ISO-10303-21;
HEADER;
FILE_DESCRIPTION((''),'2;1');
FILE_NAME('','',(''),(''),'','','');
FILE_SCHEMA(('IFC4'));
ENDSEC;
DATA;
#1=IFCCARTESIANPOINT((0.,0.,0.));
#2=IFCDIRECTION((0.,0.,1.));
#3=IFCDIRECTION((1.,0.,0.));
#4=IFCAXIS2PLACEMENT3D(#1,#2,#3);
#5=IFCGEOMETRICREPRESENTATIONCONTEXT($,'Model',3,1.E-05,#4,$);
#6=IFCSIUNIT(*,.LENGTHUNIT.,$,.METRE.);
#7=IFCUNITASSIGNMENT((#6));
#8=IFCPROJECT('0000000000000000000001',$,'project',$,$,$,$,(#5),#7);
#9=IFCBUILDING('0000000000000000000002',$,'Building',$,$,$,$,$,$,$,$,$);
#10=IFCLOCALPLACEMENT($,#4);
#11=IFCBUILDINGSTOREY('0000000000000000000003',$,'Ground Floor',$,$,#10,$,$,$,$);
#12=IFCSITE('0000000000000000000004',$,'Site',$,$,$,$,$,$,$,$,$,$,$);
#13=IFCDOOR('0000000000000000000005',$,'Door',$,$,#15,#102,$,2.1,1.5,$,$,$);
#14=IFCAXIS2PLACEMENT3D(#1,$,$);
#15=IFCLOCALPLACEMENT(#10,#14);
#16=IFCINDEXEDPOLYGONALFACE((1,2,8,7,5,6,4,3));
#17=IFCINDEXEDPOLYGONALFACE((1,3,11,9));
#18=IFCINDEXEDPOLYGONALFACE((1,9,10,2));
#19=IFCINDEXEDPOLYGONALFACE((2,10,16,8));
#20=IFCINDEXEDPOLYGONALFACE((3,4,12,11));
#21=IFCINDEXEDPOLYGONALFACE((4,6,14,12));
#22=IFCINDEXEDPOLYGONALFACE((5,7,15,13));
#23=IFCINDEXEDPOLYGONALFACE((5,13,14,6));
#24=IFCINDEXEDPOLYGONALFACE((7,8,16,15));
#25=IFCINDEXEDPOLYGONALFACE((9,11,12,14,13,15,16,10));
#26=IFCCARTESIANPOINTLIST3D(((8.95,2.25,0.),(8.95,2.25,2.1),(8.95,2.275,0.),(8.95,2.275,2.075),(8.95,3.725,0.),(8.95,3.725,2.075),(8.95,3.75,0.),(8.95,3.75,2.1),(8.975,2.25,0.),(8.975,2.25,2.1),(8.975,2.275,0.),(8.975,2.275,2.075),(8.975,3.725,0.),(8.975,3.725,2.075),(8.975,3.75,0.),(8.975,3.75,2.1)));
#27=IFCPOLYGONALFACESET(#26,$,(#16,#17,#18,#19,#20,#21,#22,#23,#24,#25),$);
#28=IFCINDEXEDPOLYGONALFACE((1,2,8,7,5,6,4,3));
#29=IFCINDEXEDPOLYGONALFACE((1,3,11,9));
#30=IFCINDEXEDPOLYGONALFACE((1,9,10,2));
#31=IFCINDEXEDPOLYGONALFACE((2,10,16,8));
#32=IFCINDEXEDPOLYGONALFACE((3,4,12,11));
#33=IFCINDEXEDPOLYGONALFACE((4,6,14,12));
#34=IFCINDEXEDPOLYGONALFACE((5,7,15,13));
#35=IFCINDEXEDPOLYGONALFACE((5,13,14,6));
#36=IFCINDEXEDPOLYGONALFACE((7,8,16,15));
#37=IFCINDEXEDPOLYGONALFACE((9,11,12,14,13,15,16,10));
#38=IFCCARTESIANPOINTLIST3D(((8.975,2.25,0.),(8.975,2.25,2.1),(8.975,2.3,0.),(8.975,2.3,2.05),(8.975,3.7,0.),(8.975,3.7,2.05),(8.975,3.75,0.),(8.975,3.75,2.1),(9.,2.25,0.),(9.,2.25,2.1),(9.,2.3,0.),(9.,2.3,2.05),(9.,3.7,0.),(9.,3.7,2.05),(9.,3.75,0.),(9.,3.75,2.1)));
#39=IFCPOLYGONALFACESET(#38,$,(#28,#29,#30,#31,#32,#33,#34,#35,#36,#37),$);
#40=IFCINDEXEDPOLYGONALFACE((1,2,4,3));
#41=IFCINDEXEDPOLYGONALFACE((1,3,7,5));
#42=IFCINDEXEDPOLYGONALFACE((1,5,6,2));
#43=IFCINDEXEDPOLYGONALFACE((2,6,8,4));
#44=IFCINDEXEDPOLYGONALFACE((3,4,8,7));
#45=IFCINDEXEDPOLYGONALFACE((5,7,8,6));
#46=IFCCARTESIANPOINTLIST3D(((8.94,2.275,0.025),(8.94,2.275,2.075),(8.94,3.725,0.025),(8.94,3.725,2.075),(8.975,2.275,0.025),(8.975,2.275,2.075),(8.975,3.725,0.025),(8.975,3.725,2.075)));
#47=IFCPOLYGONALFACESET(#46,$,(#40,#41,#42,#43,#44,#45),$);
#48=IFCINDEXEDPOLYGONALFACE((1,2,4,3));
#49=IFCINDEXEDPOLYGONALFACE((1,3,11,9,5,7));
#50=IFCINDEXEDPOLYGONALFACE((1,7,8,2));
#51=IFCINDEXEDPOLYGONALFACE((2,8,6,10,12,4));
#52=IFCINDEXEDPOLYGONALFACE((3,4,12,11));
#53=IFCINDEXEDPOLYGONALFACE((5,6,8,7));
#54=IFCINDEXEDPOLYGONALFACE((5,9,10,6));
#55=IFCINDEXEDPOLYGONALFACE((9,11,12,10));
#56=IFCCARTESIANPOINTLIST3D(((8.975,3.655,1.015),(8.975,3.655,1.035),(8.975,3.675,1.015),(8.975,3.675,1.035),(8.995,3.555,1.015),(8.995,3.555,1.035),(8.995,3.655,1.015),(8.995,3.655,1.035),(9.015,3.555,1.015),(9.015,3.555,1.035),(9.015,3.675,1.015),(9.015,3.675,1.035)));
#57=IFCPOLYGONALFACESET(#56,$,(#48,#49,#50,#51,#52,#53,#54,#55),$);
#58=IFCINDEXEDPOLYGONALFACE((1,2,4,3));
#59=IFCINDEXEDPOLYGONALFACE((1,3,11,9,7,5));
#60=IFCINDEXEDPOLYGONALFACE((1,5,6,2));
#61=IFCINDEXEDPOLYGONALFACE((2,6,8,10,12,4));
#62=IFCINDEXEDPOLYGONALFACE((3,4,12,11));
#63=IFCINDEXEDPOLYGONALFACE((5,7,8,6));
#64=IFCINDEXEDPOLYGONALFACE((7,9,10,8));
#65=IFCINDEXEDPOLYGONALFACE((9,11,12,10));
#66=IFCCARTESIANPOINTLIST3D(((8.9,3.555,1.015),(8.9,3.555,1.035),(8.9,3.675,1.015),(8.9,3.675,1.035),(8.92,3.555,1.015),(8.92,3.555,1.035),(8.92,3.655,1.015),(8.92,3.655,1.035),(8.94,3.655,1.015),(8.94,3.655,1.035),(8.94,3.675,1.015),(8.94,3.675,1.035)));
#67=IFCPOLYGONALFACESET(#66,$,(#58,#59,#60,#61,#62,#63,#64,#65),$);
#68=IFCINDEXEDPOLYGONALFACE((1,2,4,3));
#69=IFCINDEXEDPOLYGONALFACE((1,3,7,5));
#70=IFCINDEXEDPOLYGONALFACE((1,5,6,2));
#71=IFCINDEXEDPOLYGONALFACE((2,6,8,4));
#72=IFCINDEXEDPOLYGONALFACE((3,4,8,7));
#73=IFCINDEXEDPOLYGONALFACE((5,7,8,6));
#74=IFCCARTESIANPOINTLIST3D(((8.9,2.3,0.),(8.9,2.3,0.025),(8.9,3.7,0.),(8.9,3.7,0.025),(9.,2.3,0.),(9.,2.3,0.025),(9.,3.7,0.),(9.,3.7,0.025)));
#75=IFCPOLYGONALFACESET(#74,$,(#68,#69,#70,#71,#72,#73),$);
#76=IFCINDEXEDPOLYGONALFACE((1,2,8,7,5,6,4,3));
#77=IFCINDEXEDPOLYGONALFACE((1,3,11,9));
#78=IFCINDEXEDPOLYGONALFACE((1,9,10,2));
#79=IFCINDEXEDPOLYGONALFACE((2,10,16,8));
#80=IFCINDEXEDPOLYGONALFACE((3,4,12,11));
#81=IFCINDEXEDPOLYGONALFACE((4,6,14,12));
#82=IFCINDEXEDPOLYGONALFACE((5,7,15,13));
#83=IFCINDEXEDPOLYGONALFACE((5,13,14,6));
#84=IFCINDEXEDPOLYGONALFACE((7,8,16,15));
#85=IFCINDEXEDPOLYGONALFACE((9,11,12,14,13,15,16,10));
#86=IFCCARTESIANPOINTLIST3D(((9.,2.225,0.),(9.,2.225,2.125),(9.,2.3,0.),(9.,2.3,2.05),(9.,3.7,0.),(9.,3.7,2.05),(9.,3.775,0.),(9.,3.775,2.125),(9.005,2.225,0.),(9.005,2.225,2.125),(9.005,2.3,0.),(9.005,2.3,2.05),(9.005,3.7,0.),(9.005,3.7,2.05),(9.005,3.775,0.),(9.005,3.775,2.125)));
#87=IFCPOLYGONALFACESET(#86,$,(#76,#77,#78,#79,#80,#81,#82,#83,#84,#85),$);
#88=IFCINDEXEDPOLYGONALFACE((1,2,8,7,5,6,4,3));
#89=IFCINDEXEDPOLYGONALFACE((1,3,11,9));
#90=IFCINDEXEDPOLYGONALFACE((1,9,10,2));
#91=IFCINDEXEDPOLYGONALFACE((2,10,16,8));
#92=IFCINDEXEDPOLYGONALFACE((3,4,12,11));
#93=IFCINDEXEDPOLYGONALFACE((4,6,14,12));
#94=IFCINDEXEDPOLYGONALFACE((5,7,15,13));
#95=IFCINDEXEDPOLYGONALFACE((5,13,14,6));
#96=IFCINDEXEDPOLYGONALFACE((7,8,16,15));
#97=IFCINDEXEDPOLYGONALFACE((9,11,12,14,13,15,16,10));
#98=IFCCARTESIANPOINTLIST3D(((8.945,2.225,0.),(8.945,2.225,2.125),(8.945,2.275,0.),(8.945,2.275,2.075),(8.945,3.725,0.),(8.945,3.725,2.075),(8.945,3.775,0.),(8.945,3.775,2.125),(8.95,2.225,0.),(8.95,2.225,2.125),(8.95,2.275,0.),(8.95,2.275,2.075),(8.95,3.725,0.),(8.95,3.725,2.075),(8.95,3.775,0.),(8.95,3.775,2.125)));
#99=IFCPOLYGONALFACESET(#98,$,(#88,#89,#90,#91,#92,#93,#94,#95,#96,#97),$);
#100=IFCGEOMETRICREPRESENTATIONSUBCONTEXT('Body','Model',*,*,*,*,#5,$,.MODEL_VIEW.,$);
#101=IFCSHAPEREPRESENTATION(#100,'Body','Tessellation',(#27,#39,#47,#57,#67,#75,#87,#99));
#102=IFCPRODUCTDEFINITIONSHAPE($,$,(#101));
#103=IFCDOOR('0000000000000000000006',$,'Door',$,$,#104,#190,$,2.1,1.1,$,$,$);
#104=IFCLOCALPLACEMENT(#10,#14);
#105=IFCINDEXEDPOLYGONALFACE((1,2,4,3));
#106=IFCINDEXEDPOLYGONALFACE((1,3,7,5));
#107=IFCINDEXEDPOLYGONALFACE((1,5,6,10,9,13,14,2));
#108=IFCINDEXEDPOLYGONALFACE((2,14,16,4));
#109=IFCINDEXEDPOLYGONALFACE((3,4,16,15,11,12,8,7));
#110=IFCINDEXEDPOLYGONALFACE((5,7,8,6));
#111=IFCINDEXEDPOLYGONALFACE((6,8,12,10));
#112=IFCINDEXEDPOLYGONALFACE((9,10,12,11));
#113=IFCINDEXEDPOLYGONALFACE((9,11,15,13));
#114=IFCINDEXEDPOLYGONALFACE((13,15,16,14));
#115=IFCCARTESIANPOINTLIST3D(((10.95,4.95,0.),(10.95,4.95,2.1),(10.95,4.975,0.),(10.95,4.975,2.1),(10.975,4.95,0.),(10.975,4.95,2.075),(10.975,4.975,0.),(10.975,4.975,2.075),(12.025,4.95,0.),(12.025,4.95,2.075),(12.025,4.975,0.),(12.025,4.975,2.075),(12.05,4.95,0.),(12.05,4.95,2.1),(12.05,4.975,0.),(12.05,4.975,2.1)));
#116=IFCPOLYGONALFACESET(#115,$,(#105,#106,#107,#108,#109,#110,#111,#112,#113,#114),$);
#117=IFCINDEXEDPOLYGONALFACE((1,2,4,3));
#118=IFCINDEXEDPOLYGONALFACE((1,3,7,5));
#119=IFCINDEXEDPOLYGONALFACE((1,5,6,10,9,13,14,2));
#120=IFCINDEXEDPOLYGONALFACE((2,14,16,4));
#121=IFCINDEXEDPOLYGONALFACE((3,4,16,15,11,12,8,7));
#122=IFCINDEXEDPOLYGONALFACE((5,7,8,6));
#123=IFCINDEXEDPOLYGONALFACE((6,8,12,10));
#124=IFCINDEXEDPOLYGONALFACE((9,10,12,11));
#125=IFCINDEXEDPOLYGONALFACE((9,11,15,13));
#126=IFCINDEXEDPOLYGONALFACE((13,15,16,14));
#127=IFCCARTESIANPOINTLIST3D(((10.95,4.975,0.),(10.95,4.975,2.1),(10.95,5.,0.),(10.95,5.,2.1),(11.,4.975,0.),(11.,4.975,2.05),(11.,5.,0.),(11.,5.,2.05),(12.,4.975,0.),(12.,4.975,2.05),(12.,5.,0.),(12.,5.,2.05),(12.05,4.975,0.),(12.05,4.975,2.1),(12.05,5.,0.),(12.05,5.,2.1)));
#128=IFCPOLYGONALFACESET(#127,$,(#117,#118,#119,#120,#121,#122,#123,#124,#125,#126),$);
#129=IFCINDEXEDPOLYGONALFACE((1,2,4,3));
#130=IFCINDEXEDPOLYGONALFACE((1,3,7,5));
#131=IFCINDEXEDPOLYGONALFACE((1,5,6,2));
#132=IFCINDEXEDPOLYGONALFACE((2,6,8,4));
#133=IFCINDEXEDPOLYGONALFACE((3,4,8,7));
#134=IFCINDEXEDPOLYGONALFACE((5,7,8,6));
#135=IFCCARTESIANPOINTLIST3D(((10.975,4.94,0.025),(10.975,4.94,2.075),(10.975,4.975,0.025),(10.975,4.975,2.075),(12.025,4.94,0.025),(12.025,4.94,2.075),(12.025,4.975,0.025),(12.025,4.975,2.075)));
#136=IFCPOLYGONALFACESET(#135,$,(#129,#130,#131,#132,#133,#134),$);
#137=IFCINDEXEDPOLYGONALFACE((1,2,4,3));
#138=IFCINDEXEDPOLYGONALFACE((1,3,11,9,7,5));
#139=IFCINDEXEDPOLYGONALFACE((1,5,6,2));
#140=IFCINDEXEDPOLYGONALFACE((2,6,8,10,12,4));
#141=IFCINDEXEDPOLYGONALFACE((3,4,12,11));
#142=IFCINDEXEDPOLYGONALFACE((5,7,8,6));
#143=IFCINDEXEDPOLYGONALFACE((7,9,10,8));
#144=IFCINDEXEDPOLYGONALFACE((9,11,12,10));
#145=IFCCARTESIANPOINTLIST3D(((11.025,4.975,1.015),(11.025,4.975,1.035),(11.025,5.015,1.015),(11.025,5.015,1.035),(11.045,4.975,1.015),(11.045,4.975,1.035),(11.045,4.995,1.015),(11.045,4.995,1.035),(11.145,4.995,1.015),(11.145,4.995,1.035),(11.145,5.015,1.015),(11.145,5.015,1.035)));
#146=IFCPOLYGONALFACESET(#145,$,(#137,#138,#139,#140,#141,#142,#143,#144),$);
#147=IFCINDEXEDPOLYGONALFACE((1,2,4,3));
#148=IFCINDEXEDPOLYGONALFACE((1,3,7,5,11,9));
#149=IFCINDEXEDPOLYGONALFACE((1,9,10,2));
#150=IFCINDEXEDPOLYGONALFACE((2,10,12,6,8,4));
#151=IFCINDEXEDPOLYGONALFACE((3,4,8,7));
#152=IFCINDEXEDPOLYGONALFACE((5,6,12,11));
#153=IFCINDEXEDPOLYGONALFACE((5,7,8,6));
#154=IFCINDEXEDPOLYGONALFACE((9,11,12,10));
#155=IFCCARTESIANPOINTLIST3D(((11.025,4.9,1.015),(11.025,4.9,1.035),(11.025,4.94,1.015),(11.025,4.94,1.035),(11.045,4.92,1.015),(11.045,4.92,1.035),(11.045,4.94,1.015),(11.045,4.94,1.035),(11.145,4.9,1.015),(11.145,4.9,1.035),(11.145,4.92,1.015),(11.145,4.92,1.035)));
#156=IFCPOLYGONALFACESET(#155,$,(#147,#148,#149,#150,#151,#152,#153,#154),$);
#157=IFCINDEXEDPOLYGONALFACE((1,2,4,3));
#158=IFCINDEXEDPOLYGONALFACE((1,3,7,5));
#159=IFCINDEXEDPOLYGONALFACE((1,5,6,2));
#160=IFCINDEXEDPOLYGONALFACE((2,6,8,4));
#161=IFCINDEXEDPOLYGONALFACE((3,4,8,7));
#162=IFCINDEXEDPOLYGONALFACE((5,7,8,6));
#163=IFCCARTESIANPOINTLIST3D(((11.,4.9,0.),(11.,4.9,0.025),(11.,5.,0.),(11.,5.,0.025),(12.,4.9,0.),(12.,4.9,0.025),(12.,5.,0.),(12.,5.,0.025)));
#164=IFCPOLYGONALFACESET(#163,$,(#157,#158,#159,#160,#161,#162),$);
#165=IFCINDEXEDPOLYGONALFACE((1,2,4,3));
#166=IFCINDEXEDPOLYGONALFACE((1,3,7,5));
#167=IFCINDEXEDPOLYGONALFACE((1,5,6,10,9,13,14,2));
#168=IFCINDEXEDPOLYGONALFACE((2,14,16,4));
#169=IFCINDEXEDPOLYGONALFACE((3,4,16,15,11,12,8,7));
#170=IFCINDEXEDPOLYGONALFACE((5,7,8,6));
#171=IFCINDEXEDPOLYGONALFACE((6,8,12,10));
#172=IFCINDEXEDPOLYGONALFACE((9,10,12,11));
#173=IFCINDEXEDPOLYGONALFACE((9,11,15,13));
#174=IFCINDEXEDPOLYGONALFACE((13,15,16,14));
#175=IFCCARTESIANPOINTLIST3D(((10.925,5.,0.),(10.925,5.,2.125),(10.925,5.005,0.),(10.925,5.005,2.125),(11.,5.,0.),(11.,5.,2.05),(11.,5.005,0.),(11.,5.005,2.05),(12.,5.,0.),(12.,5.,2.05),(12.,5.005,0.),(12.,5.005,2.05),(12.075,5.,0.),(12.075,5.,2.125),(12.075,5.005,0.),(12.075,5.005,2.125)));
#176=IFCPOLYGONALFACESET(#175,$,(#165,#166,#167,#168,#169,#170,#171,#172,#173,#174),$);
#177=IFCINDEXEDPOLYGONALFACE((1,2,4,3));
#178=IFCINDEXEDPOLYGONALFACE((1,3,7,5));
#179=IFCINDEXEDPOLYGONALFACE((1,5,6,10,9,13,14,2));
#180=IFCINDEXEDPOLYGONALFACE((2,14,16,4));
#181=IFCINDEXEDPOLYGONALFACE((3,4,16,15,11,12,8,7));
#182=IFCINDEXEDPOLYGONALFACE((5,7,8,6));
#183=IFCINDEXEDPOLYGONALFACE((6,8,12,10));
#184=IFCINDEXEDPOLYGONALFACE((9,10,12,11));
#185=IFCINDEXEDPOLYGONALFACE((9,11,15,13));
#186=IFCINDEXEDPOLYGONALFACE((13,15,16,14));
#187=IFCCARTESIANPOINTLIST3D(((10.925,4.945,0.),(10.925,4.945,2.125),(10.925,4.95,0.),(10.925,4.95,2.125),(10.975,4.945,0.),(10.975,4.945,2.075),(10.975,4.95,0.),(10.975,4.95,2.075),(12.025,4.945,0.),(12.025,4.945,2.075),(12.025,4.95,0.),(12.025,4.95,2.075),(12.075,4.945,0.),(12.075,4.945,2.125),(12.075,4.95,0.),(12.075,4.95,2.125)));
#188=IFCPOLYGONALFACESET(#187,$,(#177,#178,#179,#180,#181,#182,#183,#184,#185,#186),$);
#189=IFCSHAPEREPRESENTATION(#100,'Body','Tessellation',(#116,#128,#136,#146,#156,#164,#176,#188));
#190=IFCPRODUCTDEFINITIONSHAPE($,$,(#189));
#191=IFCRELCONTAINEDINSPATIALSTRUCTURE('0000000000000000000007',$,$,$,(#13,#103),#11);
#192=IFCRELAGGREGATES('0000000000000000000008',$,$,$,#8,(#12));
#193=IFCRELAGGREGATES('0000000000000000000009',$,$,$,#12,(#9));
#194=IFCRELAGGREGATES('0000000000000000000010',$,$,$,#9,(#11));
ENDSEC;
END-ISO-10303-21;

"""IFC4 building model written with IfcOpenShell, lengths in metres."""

from ifc_helpers import new_model, si_unit, frame, origin_with_axes, place, context, subcontext, project, spatial, line, indexed_curve, outline, extrude, element, save


model = new_model("IFC4")

# Units and contexts
model_context = context("Model", 3, precision=1e-05, world=origin_with_axes())
body_context = subcontext(model_context, "Body", "Model", "MODEL_VIEW")
ifc_project = project(units=[si_unit("LENGTHUNIT", "METRE")], contexts=[model_context])

# Site, building, storey
site = spatial("IfcSite", under=ifc_project, Name="Site")
building = spatial("IfcBuilding", under=site, Name="Building")
storey_placement = place(None, origin_with_axes())
storey = spatial("IfcBuildingStorey", under=building, at=storey_placement, Name="Ground Floor")

# Doors
door_1_placement = place(storey_placement, frame((9.0, 2.25, 0.0), z_axis=(0.0, 0.0, 1.0), x_axis=(0.0, 1.0, 0.0)))
element("IfcDoor", 1, at=door_1_placement, inside=storey, Name="Door", OverallHeight=2.1, OverallWidth=1.5, context=body_context, shape_type="SweptSolid", body=[
    extrude(outline(indexed_curve([(0.0, 0.0), (0.0, 2.1), (1.5, 2.1), (1.5, 0.0), (1.475, 0.0), (1.475, 2.075), (0.025, 2.075), (0.025, 0.0)], segments=[line(1, 2, 3, 4, 5, 6, 7, 8, 1)])), frame((0.0, 0.025, 0.0), z_axis=(0.0, -1.0, 0.0), x_axis=(1.0, 0.0, 0.0)), (0.0, 0.0, -1.0), 0.025),
    extrude(outline(indexed_curve([(0.0, 0.0), (0.0, 2.1), (1.5, 2.1), (1.5, 0.0), (1.45, 0.0), (1.45, 2.05), (0.05, 2.05), (0.05, 0.0)], segments=[line(1, 2, 3, 4, 5, 6, 7, 8, 1)])), frame((0.0, 0.0, 0.0), z_axis=(0.0, -1.0, 0.0), x_axis=(1.0, 0.0, 0.0)), (0.0, 0.0, -1.0), 0.025),
    extrude(outline(indexed_curve([(0.0, 0.0), (1.45, 0.0), (1.45, 0.035), (0.0, 0.035)], segments=[line(1, 2, 3, 4, 1)])), frame((0.025, 0.025, 0.025), z_axis=(0.0, 0.0, 1.0), x_axis=(1.0, 0.0, 0.0)), (0.0, 0.0, 1.0), 2.05),
    extrude(outline(indexed_curve([(0.0, 0.0), (0.0, -0.04), (-0.12, -0.04), (-0.12, -0.02), (-0.02, -0.02), (-0.02, 0.0)], segments=[line(1, 2, 3, 4, 5, 6, 1)])), frame((1.425, 0.025, 1.015), z_axis=(0.0, 0.0, 1.0), x_axis=(1.0, 0.0, 0.0)), (0.0, 0.0, 1.0), 0.02),
    extrude(outline(indexed_curve([(0.0, 0.0), (0.0, 0.04), (-0.12, 0.04), (-0.12, 0.02), (-0.02, 0.02), (-0.02, 0.0)], segments=[line(1, 2, 3, 4, 5, 6, 1)])), frame((1.425, 0.06, 1.015), z_axis=(0.0, 0.0, 1.0), x_axis=(1.0, 0.0, 0.0)), (0.0, 0.0, 1.0), 0.02),
    extrude(outline(indexed_curve([(0.0, 0.0), (1.4, 0.0), (1.4, 0.1), (0.0, 0.1)], segments=[line(1, 2, 3, 4, 1)])), frame((0.05, 0.0, 0.0), z_axis=(0.0, 0.0, 1.0), x_axis=(1.0, 0.0, 0.0)), (0.0, 0.0, 1.0), 0.025),
    extrude(outline(indexed_curve([(0.0, 0.0), (0.0, 2.125), (1.55, 2.125), (1.55, 0.0), (1.475, 0.0), (1.475, 2.05), (0.075, 2.05), (0.075, 0.0)], segments=[line(1, 2, 3, 4, 5, 6, 7, 8, 1)])), frame((-0.025, -0.005, 0.0), z_axis=(0.0, -1.0, 0.0), x_axis=(1.0, 0.0, 0.0)), (0.0, 0.0, -1.0), 0.005),
    extrude(outline(indexed_curve([(0.0, 0.0), (0.0, 2.125), (1.55, 2.125), (1.55, 0.0), (1.5, 0.0), (1.5, 2.075), (0.05, 2.075), (0.05, 0.0)], segments=[line(1, 2, 3, 4, 5, 6, 7, 8, 1)])), frame((-0.025, 0.05, 0.0), z_axis=(0.0, -1.0, 0.0), x_axis=(1.0, 0.0, 0.0)), (0.0, 0.0, -1.0), 0.005),
])
door_2_placement = place(storey_placement, frame((12.05, 5.0, 0.0), z_axis=(0.0, 0.0, 1.0), x_axis=(-1.0, 0.0, 0.0)))
element("IfcDoor", 2, at=door_2_placement, inside=storey, Name="Door", OverallHeight=2.1, OverallWidth=1.1, context=body_context, shape_type="SweptSolid", body=[
    extrude(outline(indexed_curve([(0.0, 0.0), (0.0, 2.1), (1.1, 2.1), (1.1, 0.0), (1.075, 0.0), (1.075, 2.075), (0.025, 2.075), (0.025, 0.0)], segments=[line(1, 2, 3, 4, 5, 6, 7, 8, 1)])), frame((0.0, 0.025, 0.0), z_axis=(0.0, -1.0, 0.0), x_axis=(1.0, 0.0, 0.0)), (0.0, 0.0, -1.0), 0.025),
    extrude(outline(indexed_curve([(0.0, 0.0), (0.0, 2.1), (1.1, 2.1), (1.1, 0.0), (1.05, 0.0), (1.05, 2.05), (0.05, 2.05), (0.05, 0.0)], segments=[line(1, 2, 3, 4, 5, 6, 7, 8, 1)])), frame((0.0, 0.0, 0.0), z_axis=(0.0, -1.0, 0.0), x_axis=(1.0, 0.0, 0.0)), (0.0, 0.0, -1.0), 0.025),
    extrude(outline(indexed_curve([(0.0, 0.0), (1.05, 0.0), (1.05, 0.035), (0.0, 0.035)], segments=[line(1, 2, 3, 4, 1)])), frame((0.025, 0.025, 0.025), z_axis=(0.0, 0.0, 1.0), x_axis=(1.0, 0.0, 0.0)), (0.0, 0.0, 1.0), 2.05),
    extrude(outline(indexed_curve([(0.0, 0.0), (0.0, -0.04), (-0.12, -0.04), (-0.12, -0.02), (-0.02, -0.02), (-0.02, 0.0)], segments=[line(1, 2, 3, 4, 5, 6, 1)])), frame((1.025, 0.025, 1.015), z_axis=(0.0, 0.0, 1.0), x_axis=(1.0, 0.0, 0.0)), (0.0, 0.0, 1.0), 0.02),
    extrude(outline(indexed_curve([(0.0, 0.0), (0.0, 0.04), (-0.12, 0.04), (-0.12, 0.02), (-0.02, 0.02), (-0.02, 0.0)], segments=[line(1, 2, 3, 4, 5, 6, 1)])), frame((1.025, 0.06, 1.015), z_axis=(0.0, 0.0, 1.0), x_axis=(1.0, 0.0, 0.0)), (0.0, 0.0, 1.0), 0.02),
    extrude(outline(indexed_curve([(0.0, 0.0), (1.0, 0.0), (1.0, 0.1), (0.0, 0.1)], segments=[line(1, 2, 3, 4, 1)])), frame((0.05, 0.0, 0.0), z_axis=(0.0, 0.0, 1.0), x_axis=(1.0, 0.0, 0.0)), (0.0, 0.0, 1.0), 0.025),
    extrude(outline(indexed_curve([(0.0, 0.0), (0.0, 2.125), (1.15, 2.125), (1.15, 0.0), (1.075, 0.0), (1.075, 2.05), (0.075, 2.05), (0.075, 0.0)], segments=[line(1, 2, 3, 4, 5, 6, 7, 8, 1)])), frame((-0.025, -0.005, 0.0), z_axis=(0.0, -1.0, 0.0), x_axis=(1.0, 0.0, 0.0)), (0.0, 0.0, -1.0), 0.005),
    extrude(outline(indexed_curve([(0.0, 0.0), (0.0, 2.125), (1.15, 2.125), (1.15, 0.0), (1.1, 0.0), (1.1, 2.075), (0.05, 2.075), (0.05, 0.0)], segments=[line(1, 2, 3, 4, 5, 6, 7, 8, 1)])), frame((-0.025, 0.05, 0.0), z_axis=(0.0, -1.0, 0.0), x_axis=(1.0, 0.0, 0.0)), (0.0, 0.0, -1.0), 0.005),
])

save(model, "model.ifc")
